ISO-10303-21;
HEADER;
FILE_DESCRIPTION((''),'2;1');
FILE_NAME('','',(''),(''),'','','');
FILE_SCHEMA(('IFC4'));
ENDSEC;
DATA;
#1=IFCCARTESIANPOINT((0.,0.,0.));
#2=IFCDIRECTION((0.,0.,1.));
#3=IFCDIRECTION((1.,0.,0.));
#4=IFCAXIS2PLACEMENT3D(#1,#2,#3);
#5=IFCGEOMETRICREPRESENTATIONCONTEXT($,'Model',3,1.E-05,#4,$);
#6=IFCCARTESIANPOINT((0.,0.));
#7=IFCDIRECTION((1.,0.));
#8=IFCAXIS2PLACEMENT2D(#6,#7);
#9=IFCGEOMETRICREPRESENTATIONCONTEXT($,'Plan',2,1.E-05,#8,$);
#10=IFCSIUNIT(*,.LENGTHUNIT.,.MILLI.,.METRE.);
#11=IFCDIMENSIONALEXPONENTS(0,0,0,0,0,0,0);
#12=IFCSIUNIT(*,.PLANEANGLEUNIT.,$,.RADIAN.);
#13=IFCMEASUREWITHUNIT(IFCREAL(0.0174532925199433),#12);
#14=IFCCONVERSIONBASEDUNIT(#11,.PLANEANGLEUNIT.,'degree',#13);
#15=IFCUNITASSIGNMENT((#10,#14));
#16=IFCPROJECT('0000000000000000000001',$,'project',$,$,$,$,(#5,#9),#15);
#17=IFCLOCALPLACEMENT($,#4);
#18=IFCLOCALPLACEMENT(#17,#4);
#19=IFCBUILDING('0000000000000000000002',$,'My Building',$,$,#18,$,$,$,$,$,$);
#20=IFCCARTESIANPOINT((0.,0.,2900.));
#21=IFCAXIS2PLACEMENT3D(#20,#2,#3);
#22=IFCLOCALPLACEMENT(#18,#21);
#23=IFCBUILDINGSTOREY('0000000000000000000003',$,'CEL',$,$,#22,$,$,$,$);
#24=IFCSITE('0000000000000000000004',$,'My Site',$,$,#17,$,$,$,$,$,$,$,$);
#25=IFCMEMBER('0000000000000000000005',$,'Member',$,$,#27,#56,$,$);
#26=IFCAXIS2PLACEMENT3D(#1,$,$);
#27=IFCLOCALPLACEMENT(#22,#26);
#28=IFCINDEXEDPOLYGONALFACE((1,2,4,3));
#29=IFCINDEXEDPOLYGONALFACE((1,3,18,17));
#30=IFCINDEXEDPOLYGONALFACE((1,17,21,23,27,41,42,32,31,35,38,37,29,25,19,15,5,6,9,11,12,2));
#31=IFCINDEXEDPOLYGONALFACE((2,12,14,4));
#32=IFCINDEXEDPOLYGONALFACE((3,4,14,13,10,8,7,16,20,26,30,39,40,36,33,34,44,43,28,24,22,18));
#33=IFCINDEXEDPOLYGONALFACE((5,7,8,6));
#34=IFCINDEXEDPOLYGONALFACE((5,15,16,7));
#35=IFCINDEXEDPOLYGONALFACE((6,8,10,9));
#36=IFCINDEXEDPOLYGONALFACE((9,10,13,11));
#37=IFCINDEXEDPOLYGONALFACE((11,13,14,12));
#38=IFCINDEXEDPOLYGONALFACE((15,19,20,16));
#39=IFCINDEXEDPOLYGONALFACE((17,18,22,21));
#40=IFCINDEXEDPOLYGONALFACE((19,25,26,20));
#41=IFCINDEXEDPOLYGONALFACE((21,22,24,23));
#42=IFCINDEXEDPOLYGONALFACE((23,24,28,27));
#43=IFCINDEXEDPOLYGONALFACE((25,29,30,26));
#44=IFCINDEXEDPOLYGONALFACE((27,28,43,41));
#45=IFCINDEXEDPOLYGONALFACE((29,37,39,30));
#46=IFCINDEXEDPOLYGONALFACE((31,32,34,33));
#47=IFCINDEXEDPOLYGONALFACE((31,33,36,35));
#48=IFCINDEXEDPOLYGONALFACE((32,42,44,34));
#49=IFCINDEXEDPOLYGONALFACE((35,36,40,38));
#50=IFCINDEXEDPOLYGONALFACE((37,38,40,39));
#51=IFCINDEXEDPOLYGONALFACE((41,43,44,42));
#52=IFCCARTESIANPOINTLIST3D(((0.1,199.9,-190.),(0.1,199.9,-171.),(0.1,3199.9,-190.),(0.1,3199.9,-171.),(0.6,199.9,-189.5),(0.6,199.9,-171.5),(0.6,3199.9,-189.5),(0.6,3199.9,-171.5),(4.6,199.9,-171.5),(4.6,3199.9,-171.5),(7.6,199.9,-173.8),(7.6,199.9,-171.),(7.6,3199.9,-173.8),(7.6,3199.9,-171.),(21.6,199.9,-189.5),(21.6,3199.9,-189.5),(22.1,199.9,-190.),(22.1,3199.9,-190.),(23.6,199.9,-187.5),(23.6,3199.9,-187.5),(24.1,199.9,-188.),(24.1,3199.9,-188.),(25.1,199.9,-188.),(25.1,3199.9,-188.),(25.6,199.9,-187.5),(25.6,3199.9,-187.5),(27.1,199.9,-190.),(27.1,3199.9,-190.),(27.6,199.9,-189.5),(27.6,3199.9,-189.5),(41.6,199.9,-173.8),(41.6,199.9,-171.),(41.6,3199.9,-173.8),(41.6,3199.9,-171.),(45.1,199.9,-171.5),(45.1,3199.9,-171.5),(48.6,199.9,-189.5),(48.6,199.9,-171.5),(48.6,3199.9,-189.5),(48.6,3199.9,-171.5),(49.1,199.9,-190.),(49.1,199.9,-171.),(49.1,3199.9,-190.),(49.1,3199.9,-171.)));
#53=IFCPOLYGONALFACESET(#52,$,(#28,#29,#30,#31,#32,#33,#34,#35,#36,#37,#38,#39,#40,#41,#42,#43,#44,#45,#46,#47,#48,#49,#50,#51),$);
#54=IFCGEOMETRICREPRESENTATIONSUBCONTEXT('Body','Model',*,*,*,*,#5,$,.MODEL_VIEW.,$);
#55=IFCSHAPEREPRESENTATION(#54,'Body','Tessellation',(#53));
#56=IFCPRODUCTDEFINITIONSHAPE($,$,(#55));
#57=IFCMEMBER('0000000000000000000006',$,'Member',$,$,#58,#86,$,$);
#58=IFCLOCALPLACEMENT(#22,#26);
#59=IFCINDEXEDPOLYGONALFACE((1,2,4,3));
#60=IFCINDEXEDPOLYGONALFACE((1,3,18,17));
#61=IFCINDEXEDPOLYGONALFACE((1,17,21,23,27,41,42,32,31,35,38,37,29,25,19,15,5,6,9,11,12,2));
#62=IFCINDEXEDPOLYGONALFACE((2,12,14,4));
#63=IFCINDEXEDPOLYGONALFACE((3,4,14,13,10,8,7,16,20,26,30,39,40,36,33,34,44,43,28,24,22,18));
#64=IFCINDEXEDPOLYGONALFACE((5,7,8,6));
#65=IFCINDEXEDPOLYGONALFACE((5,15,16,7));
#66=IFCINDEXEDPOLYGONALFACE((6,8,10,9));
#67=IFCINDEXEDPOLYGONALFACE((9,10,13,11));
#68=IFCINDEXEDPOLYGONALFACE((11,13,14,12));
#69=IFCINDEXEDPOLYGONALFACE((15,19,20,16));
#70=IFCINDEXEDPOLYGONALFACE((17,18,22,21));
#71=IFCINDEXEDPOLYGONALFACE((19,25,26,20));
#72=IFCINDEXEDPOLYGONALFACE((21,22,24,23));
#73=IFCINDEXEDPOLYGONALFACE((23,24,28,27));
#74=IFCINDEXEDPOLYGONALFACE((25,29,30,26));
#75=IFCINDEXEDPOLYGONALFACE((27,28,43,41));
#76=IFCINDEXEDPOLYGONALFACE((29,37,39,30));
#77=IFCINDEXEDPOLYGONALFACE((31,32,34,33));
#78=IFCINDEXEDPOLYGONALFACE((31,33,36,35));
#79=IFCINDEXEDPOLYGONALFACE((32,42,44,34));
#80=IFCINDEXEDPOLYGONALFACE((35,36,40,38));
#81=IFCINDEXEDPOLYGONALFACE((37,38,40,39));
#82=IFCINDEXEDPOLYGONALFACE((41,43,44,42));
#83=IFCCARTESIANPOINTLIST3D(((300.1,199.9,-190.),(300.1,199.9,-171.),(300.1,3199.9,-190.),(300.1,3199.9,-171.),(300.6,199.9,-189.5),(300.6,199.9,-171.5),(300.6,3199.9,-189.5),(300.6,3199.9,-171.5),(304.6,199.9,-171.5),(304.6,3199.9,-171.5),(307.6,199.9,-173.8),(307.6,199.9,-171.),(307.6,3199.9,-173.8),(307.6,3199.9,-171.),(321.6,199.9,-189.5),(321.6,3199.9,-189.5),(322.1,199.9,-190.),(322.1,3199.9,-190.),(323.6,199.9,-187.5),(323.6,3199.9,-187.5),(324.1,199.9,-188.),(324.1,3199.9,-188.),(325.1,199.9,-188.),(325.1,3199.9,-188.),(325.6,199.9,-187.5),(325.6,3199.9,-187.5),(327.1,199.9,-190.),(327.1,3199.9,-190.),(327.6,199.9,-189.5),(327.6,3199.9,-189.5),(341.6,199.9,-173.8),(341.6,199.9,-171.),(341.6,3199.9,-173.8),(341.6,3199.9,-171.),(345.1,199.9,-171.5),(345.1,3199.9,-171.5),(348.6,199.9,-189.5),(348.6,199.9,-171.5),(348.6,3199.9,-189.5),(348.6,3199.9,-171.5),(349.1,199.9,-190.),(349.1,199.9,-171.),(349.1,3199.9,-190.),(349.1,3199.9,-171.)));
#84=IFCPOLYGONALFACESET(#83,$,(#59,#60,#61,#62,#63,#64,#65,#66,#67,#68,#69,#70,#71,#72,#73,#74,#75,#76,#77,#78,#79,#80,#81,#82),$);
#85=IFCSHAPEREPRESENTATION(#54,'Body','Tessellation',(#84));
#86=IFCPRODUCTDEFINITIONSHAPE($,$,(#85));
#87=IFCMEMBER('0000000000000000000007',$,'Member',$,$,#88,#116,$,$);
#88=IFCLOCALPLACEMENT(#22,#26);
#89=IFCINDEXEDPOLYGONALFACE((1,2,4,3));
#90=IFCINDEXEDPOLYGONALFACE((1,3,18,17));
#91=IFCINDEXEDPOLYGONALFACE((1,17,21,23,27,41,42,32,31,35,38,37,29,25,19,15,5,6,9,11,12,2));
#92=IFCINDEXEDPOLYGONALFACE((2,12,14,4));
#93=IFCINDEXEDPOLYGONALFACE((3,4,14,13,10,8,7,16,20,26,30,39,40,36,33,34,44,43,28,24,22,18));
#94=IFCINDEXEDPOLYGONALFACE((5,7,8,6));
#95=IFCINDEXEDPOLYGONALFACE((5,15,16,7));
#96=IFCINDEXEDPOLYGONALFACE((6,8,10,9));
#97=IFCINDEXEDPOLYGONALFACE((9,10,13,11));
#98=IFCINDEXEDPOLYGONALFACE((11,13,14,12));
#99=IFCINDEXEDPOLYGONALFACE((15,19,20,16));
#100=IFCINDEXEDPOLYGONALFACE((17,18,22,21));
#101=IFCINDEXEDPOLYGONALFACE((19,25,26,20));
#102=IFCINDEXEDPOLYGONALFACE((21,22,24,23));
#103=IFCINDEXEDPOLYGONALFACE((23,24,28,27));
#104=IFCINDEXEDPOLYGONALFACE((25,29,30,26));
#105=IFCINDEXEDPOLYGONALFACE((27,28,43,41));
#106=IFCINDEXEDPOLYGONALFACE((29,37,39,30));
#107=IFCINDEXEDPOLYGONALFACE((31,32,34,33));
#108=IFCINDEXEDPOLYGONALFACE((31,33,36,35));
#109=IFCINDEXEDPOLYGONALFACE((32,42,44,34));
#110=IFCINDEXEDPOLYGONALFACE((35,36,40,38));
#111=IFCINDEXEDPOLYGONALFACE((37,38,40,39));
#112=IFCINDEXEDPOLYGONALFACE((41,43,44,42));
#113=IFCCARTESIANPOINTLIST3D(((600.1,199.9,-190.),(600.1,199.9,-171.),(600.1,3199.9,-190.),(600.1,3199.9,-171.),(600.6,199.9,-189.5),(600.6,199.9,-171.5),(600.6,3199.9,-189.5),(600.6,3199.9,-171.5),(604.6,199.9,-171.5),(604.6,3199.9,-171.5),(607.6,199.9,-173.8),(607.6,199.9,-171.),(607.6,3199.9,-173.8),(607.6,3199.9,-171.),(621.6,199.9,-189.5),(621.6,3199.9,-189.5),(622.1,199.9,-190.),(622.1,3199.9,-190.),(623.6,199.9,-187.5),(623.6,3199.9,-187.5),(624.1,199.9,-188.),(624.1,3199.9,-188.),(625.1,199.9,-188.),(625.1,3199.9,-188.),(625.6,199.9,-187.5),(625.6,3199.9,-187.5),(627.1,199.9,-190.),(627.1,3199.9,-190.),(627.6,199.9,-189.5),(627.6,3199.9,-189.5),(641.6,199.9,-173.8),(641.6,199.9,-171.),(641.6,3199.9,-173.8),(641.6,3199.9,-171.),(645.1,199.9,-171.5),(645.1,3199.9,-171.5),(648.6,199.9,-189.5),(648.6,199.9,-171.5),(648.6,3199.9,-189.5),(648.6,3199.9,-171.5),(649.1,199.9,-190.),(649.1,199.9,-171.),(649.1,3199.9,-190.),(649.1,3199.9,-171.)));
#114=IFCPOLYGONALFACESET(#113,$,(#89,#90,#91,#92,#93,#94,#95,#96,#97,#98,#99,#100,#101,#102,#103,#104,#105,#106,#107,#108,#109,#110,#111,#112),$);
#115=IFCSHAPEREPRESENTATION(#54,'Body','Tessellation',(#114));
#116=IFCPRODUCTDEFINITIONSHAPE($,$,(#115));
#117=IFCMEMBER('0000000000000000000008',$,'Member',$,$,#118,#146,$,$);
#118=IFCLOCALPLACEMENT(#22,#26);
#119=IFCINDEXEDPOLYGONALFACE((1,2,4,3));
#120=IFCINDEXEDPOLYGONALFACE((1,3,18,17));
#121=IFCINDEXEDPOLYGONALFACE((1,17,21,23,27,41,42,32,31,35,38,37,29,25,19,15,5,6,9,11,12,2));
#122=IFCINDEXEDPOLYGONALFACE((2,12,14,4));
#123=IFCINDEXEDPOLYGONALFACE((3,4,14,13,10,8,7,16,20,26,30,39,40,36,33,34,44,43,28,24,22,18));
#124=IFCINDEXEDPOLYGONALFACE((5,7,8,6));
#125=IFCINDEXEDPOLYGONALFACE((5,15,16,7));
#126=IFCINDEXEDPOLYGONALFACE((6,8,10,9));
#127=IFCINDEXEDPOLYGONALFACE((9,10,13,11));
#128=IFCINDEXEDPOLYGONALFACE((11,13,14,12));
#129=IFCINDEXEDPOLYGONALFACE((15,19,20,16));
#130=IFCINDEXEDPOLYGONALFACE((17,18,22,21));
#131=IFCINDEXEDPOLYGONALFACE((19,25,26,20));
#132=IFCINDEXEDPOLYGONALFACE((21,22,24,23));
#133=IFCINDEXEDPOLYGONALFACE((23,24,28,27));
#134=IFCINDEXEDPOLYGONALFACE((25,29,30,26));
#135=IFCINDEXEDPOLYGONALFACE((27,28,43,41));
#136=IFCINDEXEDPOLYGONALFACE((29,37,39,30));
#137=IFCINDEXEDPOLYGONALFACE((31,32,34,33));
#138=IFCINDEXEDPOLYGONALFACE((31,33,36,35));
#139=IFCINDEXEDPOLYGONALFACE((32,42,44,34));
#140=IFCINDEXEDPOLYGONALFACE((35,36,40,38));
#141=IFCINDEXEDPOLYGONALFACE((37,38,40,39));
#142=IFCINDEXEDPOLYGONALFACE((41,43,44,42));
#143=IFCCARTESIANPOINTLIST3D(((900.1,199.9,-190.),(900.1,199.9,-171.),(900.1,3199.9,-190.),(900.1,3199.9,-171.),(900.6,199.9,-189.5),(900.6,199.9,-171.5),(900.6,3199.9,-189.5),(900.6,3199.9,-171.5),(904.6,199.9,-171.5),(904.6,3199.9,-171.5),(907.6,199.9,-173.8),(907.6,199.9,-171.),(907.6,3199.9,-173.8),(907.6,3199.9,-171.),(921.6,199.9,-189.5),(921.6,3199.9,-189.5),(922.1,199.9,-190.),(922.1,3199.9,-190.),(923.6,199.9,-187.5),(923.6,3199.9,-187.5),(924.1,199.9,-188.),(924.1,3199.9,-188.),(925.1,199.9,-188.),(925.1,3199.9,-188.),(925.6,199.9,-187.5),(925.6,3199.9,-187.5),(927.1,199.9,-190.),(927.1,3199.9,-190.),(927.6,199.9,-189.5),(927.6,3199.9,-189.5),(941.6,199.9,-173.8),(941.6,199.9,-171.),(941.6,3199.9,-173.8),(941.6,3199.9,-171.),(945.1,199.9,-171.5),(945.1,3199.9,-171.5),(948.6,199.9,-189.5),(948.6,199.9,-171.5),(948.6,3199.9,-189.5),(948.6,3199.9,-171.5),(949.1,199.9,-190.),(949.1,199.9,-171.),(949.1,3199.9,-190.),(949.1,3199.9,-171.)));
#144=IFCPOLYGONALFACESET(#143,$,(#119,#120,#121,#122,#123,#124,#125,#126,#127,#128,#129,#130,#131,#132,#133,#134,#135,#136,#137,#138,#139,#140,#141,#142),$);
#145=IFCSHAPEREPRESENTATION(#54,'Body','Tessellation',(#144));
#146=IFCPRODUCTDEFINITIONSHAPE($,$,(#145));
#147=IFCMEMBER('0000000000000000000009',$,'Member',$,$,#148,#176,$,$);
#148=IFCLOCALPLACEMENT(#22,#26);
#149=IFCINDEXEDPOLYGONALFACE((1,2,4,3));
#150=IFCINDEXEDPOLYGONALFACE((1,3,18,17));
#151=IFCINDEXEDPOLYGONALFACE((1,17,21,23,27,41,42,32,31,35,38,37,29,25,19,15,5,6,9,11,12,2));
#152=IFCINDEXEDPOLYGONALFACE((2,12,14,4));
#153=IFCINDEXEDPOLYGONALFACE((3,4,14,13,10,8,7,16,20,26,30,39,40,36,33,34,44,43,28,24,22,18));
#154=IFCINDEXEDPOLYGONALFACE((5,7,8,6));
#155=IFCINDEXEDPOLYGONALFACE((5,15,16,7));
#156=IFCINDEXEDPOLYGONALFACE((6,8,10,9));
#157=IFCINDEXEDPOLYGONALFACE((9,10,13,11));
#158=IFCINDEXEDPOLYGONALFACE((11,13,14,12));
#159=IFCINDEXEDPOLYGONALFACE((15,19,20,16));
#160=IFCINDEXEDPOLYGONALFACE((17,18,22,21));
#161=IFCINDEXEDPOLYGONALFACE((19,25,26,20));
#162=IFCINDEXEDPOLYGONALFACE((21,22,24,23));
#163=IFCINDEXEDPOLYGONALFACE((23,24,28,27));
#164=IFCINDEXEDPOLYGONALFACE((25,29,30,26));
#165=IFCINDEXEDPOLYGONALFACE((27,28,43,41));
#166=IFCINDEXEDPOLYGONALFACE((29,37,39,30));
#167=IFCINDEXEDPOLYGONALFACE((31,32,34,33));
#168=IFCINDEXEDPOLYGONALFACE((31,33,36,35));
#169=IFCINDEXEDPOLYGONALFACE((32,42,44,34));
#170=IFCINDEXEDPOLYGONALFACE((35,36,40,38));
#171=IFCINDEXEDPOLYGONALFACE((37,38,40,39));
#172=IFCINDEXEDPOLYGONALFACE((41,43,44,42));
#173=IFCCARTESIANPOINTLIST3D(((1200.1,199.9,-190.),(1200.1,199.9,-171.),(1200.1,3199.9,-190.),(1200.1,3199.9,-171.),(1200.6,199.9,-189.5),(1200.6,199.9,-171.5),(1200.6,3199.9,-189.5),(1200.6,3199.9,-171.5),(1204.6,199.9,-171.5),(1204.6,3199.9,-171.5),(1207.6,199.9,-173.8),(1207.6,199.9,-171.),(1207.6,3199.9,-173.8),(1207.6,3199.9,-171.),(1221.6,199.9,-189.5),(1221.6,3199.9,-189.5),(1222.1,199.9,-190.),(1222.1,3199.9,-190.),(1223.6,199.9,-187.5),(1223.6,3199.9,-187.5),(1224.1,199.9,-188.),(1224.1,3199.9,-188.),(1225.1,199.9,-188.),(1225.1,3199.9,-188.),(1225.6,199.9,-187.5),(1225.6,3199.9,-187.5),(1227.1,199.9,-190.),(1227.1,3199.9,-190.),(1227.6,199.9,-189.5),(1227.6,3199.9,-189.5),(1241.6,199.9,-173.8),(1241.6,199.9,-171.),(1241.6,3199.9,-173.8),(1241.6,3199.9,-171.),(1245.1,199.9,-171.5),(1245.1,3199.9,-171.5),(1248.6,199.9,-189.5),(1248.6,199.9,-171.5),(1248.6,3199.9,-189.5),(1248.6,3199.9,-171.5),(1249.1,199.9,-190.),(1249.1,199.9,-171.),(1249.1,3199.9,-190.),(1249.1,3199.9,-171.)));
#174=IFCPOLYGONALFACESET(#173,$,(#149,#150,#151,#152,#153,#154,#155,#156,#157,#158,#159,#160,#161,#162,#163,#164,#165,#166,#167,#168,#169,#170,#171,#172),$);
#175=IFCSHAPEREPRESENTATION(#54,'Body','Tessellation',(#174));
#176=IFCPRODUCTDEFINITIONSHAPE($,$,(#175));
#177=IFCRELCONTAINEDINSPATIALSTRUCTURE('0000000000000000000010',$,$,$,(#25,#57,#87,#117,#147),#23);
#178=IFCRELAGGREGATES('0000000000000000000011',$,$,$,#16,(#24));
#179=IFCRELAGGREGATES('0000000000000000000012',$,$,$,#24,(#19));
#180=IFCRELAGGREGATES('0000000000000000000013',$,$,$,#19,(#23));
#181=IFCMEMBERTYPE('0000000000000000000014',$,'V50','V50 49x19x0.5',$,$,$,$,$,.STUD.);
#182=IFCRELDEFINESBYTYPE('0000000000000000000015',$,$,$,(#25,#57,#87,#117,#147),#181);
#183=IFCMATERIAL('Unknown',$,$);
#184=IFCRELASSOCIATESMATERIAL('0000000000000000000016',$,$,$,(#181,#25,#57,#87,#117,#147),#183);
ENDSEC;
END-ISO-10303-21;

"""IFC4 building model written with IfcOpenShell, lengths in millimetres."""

from ifc_helpers import new_model, entity, si_unit, converted_unit, frame, origin_with_axes, origin_2d_with_axis, place, context, subcontext, project, spatial, indexed_curve, outline, extrude, material, material_profile, profile_set, profile_usage, type_object, element, save


model = new_model("IFC4")

# Units and contexts
model_context = context("Model", 3, precision=1e-05, world=origin_with_axes())
plan_context = context("Plan", 2, precision=1e-05, world=origin_2d_with_axis())
body_context = subcontext(model_context, "Body", "Model", "MODEL_VIEW")
ifc_project = project(units=[si_unit("LENGTHUNIT", "METRE", prefix="MILLI"), converted_unit("PLANEANGLEUNIT", "degree", entity("IfcReal", 0.0174532925199433), si_unit("PLANEANGLEUNIT", "RADIAN"), dimensions=[0, 0, 0, 0, 0, 0, 0])], contexts=[model_context, plan_context])

# Site, building, storey
site_placement = place(None, origin_with_axes())
site = spatial("IfcSite", under=ifc_project, at=site_placement, Name="My Site")
building_placement = place(site_placement, origin_with_axes())
building = spatial("IfcBuilding", under=site, at=building_placement, Name="My Building")
storey_placement = place(building_placement, frame((0.0, 0.0, 2900.0), z_axis=(0.0, 0.0, 1.0), x_axis=(1.0, 0.0, 0.0)))
storey = spatial("IfcBuildingStorey", under=building, at=storey_placement, Name="CEL")

# Members
ifc_material = material(Name="Unknown")
ifc_material_profile = material_profile(ifc_material, outline(indexed_curve([(-49.0, 0.0), (-49.0, 19.0), (-41.5, 19.0), (-41.5, 16.2), (-45.0, 18.5), (-48.5, 18.5), (-48.5, 0.5), (-27.5, 0.5), (-25.5, 2.5), (-23.5, 2.5), (-21.5, 0.5), (-0.5, 0.5), (-0.5, 18.5), (-4.5, 18.5), (-7.5, 16.2), (-7.5, 19.0), (0.0, 19.0), (0.0, 0.0), (-22.0, 0.0), (-24.0, 2.0), (-25.0, 2.0), (-27.0, 0.0), (-49.0, 0.0)])))
ifc_profile_set = profile_set([ifc_material_profile])
ifc_profile_usage_1 = profile_usage(ifc_profile_set, cardinal=5)
member_type = type_object("IfcMemberType", Name="V50", Description="V50 49x19x0.5", PredefinedType="STUD", material=ifc_profile_set)
member_1_placement = place(storey_placement, frame((0.1, 199.9, -190.0), z_axis=(0.0, 1.0, 0.0), x_axis=(-1.0, 0.0, 0.0)))
element("IfcMember", 1, at=member_1_placement, inside=storey, type_object=member_type, material=ifc_profile_usage_1, Name="Member", context=body_context, shape_type="SweptSolid", body=[
    extrude(outline(indexed_curve([(-49.0, 0.0), (-49.0, 19.0), (-41.5, 19.0), (-41.5, 16.2), (-45.0, 18.5), (-48.5, 18.5), (-48.5, 0.5), (-27.5, 0.5), (-25.5, 2.5), (-23.5, 2.5), (-21.5, 0.5), (-0.5, 0.5), (-0.5, 18.5), (-4.5, 18.5), (-7.5, 16.2), (-7.5, 19.0), (0.0, 19.0), (0.0, 0.0), (-22.0, 0.0), (-24.0, 2.0), (-25.0, 2.0), (-27.0, 0.0), (-49.0, 0.0)])), origin_with_axes(), (0.0, 0.0, 1.0), 3000.0),
])
ifc_profile_usage_2 = profile_usage(ifc_profile_set, cardinal=5)
member_2_placement = place(storey_placement, frame((300.1, 199.9, -190.0), z_axis=(0.0, 1.0, 0.0), x_axis=(-1.0, 0.0, 0.0)))
element("IfcMember", 2, at=member_2_placement, inside=storey, type_object=member_type, material=ifc_profile_usage_2, Name="Member", context=body_context, shape_type="SweptSolid", body=[
    extrude(outline(indexed_curve([(-49.0, 0.0), (-49.0, 19.0), (-41.5, 19.0), (-41.5, 16.2), (-45.0, 18.5), (-48.5, 18.5), (-48.5, 0.5), (-27.5, 0.5), (-25.5, 2.5), (-23.5, 2.5), (-21.5, 0.5), (-0.5, 0.5), (-0.5, 18.5), (-4.5, 18.5), (-7.5, 16.2), (-7.5, 19.0), (0.0, 19.0), (0.0, 0.0), (-22.0, 0.0), (-24.0, 2.0), (-25.0, 2.0), (-27.0, 0.0), (-49.0, 0.0)])), origin_with_axes(), (0.0, 0.0, 1.0), 3000.0),
])
ifc_profile_usage_3 = profile_usage(ifc_profile_set, cardinal=5)
member_3_placement = place(storey_placement, frame((600.1, 199.9, -190.0), z_axis=(0.0, 1.0, 0.0), x_axis=(-1.0, 0.0, 0.0)))
element("IfcMember", 3, at=member_3_placement, inside=storey, type_object=member_type, material=ifc_profile_usage_3, Name="Member", context=body_context, shape_type="SweptSolid", body=[
    extrude(outline(indexed_curve([(-49.0, 0.0), (-49.0, 19.0), (-41.5, 19.0), (-41.5, 16.2), (-45.0, 18.5), (-48.5, 18.5), (-48.5, 0.5), (-27.5, 0.5), (-25.5, 2.5), (-23.5, 2.5), (-21.5, 0.5), (-0.5, 0.5), (-0.5, 18.5), (-4.5, 18.5), (-7.5, 16.2), (-7.5, 19.0), (0.0, 19.0), (0.0, 0.0), (-22.0, 0.0), (-24.0, 2.0), (-25.0, 2.0), (-27.0, 0.0), (-49.0, 0.0)])), origin_with_axes(), (0.0, 0.0, 1.0), 3000.0),
])
ifc_profile_usage_4 = profile_usage(ifc_profile_set, cardinal=5)
member_4_placement = place(storey_placement, frame((900.1, 199.9, -190.0), z_axis=(0.0, 1.0, 0.0), x_axis=(-1.0, 0.0, 0.0)))
element("IfcMember", 4, at=member_4_placement, inside=storey, type_object=member_type, material=ifc_profile_usage_4, Name="Member", context=body_context, shape_type="SweptSolid", body=[
    extrude(outline(indexed_curve([(-49.0, 0.0), (-49.0, 19.0), (-41.5, 19.0), (-41.5, 16.2), (-45.0, 18.5), (-48.5, 18.5), (-48.5, 0.5), (-27.5, 0.5), (-25.5, 2.5), (-23.5, 2.5), (-21.5, 0.5), (-0.5, 0.5), (-0.5, 18.5), (-4.5, 18.5), (-7.5, 16.2), (-7.5, 19.0), (0.0, 19.0), (0.0, 0.0), (-22.0, 0.0), (-24.0, 2.0), (-25.0, 2.0), (-27.0, 0.0), (-49.0, 0.0)])), origin_with_axes(), (0.0, 0.0, 1.0), 3000.0),
])
ifc_profile_usage_5 = profile_usage(ifc_profile_set, cardinal=5)
member_5_placement = place(storey_placement, frame((1200.1, 199.9, -190.0), z_axis=(0.0, 1.0, 0.0), x_axis=(-1.0, 0.0, 0.0)))
element("IfcMember", 5, at=member_5_placement, inside=storey, type_object=member_type, material=ifc_profile_usage_5, Name="Member", context=body_context, shape_type="SweptSolid", body=[
    extrude(outline(indexed_curve([(-49.0, 0.0), (-49.0, 19.0), (-41.5, 19.0), (-41.5, 16.2), (-45.0, 18.5), (-48.5, 18.5), (-48.5, 0.5), (-27.5, 0.5), (-25.5, 2.5), (-23.5, 2.5), (-21.5, 0.5), (-0.5, 0.5), (-0.5, 18.5), (-4.5, 18.5), (-7.5, 16.2), (-7.5, 19.0), (0.0, 19.0), (0.0, 0.0), (-22.0, 0.0), (-24.0, 2.0), (-25.0, 2.0), (-27.0, 0.0), (-49.0, 0.0)])), origin_with_axes(), (0.0, 0.0, 1.0), 3000.0),
])

save(model, "model.ifc")
